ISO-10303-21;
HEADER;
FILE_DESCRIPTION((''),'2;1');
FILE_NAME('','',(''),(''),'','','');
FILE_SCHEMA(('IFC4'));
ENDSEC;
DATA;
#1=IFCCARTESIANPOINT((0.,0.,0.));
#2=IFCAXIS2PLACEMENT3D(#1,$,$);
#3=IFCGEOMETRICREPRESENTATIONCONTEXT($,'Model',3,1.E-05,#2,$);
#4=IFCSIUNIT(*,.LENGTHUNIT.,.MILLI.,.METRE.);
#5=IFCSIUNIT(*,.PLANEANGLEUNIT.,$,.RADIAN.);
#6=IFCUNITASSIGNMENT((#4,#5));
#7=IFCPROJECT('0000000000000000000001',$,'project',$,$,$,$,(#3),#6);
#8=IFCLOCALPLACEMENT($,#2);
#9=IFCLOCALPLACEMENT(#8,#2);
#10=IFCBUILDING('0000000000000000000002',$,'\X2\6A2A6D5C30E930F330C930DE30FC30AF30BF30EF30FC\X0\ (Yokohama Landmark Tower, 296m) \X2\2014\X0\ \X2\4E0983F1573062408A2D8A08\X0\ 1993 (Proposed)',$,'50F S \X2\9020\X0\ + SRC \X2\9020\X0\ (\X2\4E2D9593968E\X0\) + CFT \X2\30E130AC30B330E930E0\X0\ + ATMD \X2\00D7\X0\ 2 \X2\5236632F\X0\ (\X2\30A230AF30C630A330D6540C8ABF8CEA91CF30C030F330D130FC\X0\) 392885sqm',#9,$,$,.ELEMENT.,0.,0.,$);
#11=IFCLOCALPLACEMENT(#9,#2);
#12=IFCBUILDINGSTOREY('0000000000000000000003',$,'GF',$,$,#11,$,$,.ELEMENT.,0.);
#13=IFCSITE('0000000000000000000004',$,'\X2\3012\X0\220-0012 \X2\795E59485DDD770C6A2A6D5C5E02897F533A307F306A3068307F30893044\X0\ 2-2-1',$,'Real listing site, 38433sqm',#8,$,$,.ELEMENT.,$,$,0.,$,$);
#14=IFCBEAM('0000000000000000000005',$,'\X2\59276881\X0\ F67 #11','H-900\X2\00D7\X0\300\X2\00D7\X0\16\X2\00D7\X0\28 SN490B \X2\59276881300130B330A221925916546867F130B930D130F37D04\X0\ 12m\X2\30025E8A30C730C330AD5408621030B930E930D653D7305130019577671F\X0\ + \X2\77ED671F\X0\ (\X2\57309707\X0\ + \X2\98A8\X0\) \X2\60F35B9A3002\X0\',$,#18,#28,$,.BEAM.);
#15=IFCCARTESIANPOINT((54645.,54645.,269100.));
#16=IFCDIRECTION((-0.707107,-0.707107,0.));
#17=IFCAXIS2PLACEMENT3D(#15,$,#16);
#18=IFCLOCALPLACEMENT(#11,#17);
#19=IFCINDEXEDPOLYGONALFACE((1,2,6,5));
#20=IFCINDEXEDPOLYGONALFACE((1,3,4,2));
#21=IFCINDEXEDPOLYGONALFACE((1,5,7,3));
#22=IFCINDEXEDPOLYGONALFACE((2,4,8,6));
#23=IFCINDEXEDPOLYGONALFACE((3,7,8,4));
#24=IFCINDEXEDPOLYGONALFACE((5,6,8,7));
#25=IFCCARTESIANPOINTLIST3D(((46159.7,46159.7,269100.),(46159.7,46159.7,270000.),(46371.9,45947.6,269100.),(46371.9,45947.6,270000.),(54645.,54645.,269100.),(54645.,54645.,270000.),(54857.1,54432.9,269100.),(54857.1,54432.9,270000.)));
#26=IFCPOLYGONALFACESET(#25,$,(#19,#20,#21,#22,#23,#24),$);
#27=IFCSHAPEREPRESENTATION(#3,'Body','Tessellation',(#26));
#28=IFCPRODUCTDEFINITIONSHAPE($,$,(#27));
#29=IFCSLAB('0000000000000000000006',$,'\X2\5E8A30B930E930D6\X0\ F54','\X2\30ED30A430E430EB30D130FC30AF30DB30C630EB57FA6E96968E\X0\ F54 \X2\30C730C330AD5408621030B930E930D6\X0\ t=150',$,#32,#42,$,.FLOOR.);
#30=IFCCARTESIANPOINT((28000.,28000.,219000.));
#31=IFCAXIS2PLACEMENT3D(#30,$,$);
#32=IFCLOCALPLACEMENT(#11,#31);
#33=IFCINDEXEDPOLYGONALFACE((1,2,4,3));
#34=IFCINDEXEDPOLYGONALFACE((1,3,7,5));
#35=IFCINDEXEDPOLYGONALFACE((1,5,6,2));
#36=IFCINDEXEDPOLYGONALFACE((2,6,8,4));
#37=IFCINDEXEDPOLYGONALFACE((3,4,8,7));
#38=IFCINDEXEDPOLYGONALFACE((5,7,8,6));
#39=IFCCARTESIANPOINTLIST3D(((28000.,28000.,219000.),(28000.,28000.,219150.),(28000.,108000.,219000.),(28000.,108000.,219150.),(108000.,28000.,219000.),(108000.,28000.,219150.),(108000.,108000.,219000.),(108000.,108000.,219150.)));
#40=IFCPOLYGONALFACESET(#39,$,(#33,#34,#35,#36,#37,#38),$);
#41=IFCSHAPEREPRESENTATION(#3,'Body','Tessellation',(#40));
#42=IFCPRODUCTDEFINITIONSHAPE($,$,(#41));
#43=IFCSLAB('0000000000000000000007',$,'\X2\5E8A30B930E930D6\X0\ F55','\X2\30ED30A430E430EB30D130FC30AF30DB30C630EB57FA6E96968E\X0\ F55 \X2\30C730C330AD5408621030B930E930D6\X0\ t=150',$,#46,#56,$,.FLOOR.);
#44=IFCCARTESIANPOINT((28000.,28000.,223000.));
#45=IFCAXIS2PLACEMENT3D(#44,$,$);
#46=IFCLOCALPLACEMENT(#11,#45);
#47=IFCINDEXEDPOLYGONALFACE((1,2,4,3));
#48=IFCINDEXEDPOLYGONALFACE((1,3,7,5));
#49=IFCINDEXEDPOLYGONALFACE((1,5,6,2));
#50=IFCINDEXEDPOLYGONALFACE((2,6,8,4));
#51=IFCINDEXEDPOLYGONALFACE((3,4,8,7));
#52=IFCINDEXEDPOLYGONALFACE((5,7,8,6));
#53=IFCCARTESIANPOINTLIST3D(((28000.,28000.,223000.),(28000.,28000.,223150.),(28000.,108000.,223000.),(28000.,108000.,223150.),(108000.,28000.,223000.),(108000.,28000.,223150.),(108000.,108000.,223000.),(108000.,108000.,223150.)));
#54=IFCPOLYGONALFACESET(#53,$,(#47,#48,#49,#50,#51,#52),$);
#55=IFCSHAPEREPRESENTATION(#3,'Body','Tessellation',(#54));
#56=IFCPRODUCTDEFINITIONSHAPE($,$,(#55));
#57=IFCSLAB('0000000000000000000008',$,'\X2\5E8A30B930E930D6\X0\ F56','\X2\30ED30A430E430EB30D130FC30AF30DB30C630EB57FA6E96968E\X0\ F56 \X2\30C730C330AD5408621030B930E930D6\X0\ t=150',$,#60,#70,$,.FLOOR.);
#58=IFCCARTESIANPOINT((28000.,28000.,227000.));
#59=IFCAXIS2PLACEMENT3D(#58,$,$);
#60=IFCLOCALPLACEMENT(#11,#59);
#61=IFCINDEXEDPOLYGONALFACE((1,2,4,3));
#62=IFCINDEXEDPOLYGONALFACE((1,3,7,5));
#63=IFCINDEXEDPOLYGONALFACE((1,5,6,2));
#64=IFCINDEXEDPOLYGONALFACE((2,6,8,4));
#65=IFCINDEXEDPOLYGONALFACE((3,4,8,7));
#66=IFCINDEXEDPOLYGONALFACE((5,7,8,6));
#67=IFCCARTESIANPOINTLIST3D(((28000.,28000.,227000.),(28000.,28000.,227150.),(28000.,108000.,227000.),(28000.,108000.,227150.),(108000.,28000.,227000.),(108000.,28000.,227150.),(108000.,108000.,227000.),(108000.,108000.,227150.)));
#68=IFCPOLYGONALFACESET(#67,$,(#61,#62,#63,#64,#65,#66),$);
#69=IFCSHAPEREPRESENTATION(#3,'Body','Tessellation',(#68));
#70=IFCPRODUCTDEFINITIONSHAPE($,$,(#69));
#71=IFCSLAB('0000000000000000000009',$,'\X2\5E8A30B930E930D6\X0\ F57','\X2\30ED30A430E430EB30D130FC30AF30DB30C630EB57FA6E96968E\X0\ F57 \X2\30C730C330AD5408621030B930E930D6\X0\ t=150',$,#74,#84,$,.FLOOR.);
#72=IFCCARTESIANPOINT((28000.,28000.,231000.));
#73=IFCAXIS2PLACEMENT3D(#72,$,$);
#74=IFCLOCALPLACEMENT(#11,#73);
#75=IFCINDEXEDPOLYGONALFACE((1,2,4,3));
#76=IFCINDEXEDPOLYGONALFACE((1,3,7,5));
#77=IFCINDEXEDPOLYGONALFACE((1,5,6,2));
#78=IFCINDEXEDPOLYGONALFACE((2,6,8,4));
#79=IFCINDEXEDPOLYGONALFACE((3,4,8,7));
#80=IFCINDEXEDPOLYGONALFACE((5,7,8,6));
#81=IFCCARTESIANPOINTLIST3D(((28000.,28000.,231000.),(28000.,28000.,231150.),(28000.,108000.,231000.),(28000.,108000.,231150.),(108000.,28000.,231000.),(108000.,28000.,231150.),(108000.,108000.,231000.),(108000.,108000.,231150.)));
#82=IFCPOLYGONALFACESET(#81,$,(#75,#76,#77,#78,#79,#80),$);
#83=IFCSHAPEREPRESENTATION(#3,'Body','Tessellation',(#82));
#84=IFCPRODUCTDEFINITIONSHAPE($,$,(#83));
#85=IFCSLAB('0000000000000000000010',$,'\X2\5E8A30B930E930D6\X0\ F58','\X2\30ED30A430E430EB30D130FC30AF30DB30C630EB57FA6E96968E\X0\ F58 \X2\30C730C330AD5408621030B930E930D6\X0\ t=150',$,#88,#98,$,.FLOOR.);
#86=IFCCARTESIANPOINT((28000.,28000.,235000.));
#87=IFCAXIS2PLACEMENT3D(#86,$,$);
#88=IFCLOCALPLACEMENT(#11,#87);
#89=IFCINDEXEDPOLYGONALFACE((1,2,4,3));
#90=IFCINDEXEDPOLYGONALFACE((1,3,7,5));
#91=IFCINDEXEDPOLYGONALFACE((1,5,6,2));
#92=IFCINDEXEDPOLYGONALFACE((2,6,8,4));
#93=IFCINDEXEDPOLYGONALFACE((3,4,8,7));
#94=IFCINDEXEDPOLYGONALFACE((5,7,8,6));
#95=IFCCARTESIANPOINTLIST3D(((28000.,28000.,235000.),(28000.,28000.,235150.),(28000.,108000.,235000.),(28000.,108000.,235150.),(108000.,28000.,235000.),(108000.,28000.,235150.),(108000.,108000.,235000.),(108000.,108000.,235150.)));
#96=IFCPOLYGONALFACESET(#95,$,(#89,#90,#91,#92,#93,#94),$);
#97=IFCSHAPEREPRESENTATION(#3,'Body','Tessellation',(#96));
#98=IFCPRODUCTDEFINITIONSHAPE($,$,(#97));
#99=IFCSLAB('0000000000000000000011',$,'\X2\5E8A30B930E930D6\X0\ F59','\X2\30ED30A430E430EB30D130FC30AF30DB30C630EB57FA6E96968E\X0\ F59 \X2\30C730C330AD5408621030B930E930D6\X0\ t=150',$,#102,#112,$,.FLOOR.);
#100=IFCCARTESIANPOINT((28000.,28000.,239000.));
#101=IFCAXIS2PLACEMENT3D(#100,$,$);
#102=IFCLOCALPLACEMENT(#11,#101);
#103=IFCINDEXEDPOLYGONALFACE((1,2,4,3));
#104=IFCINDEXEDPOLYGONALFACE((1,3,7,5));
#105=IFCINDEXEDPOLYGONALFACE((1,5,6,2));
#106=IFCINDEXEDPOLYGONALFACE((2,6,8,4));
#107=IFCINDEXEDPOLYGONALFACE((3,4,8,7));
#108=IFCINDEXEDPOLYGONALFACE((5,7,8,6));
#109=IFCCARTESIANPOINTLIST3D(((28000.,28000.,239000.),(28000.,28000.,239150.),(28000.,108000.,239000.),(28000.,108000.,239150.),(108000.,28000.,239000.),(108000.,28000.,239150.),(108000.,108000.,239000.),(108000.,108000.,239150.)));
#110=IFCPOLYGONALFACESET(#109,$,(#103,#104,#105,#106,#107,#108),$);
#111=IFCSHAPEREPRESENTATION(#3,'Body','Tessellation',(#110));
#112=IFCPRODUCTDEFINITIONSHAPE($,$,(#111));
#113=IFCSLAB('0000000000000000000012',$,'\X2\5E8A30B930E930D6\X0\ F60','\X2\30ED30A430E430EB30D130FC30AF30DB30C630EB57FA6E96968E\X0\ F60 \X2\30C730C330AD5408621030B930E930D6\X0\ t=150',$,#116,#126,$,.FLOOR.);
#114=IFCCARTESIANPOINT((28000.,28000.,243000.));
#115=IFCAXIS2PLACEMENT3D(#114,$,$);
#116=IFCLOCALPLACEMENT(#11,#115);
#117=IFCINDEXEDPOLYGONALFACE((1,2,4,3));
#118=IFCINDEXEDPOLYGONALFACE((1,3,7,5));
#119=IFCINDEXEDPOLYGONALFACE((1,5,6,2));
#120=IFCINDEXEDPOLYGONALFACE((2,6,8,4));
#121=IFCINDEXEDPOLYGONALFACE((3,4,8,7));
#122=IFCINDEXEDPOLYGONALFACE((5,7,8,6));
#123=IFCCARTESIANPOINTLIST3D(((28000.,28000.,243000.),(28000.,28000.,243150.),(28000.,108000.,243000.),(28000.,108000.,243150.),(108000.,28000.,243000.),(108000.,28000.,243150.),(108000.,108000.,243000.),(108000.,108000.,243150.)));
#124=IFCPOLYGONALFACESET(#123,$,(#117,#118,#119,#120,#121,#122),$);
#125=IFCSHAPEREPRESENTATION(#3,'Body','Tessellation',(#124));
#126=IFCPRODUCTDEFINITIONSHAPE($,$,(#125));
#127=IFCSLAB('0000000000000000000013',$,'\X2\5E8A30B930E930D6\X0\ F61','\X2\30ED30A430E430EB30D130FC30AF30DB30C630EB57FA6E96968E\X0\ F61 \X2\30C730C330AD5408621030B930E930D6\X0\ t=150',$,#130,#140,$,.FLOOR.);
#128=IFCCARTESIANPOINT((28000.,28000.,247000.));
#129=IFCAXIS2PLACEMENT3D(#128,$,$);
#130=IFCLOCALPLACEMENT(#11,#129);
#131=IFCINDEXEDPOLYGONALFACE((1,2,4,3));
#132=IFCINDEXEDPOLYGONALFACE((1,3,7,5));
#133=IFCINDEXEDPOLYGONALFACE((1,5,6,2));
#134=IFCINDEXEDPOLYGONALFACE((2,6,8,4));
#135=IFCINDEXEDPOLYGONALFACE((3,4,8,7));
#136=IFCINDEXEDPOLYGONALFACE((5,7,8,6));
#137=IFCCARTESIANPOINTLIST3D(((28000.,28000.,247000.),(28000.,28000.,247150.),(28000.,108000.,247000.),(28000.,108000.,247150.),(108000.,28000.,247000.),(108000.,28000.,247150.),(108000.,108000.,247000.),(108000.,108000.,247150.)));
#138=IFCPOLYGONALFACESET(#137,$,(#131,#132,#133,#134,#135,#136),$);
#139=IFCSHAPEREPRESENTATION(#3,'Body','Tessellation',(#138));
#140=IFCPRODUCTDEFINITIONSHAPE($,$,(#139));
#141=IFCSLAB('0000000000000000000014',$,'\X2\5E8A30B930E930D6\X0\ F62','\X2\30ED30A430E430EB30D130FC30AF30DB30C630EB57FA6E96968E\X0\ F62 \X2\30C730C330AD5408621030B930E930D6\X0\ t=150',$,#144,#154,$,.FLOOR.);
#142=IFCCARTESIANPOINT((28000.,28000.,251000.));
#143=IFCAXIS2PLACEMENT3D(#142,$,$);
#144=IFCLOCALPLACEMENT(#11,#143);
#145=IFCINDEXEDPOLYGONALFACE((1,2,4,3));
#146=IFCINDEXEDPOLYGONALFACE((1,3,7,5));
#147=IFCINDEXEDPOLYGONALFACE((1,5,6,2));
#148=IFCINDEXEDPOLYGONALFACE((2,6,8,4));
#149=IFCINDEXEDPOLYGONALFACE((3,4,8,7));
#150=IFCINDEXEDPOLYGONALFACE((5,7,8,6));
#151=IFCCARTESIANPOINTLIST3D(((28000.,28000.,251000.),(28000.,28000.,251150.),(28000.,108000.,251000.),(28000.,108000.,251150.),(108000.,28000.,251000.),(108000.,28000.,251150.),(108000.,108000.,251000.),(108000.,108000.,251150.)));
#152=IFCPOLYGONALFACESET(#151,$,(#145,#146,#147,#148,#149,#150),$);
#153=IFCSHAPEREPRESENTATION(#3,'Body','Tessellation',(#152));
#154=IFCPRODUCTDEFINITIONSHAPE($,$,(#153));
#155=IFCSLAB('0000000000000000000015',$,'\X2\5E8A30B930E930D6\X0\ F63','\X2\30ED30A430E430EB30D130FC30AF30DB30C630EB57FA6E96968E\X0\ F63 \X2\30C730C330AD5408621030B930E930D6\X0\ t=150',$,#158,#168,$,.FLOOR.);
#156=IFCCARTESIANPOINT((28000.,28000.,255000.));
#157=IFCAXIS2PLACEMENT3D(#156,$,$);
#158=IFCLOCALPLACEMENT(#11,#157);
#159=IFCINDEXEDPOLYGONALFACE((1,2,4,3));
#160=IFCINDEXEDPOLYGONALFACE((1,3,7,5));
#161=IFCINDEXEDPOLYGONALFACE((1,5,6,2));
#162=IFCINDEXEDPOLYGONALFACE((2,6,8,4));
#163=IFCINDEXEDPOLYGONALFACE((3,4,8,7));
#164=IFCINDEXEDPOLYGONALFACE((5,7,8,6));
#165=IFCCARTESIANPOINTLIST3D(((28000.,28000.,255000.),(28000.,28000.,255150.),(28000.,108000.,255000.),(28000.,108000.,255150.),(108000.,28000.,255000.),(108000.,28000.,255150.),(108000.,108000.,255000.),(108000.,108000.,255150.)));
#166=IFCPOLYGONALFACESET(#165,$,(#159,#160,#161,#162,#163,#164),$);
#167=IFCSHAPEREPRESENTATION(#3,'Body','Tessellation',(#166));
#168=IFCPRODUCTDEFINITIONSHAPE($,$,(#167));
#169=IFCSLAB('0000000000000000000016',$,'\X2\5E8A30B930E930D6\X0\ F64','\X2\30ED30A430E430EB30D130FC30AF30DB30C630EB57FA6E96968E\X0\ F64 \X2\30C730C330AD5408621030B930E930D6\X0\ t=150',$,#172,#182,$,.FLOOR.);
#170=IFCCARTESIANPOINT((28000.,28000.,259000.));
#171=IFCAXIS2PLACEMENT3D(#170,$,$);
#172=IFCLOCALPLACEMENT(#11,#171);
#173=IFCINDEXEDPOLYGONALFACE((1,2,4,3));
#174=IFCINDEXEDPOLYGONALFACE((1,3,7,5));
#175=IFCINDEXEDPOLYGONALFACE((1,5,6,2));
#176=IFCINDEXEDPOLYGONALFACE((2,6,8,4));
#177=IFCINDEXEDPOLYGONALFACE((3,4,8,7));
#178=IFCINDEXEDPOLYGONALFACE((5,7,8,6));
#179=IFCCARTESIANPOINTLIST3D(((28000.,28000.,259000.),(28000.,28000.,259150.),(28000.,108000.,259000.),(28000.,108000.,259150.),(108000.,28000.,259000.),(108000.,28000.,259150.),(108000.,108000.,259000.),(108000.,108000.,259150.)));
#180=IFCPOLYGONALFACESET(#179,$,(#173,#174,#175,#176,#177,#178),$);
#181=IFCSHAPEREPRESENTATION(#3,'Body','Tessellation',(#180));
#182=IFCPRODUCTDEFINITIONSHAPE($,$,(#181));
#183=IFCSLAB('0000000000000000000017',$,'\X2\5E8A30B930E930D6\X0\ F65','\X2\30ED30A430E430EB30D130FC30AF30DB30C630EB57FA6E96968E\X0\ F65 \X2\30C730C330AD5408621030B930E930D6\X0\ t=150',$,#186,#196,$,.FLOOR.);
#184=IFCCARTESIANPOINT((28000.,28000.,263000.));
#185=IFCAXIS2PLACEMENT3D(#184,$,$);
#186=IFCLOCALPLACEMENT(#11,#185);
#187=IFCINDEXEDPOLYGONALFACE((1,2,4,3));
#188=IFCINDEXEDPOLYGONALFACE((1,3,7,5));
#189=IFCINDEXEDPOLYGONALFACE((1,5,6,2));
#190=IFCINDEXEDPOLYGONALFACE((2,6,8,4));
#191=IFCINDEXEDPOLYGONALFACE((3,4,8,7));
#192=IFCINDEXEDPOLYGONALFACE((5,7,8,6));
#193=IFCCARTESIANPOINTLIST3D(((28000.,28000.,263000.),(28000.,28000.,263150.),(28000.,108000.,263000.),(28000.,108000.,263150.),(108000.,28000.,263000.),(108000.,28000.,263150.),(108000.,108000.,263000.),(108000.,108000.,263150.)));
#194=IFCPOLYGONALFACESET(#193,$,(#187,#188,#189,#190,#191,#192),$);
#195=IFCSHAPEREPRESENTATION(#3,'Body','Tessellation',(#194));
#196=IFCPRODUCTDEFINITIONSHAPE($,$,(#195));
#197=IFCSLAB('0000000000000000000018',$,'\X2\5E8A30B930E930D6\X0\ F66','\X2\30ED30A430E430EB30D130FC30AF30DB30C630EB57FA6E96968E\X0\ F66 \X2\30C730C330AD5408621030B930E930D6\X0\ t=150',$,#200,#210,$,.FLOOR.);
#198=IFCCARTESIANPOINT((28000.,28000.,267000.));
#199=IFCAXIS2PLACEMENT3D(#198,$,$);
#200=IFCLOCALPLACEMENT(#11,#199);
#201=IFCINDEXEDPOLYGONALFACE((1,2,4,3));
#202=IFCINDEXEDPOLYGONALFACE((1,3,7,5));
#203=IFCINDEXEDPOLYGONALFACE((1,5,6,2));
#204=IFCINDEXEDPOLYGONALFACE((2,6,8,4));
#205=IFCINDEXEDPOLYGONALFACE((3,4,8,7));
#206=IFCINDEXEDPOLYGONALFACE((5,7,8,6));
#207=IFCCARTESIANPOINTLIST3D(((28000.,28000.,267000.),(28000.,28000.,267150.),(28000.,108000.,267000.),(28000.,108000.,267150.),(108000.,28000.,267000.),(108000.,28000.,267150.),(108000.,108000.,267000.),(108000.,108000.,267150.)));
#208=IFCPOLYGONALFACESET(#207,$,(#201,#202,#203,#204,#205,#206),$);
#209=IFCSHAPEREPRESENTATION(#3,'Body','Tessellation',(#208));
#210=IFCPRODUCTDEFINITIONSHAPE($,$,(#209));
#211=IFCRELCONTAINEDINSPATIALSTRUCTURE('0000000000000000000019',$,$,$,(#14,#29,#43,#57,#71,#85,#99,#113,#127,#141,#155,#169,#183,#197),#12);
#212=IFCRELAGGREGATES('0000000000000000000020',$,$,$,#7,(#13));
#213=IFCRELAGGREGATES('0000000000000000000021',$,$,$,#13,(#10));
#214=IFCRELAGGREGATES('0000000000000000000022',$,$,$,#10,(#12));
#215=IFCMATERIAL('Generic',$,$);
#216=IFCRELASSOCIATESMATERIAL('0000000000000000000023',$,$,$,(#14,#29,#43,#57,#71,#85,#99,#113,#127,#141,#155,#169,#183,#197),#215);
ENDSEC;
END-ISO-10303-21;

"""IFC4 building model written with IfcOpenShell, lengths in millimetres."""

from ifc_helpers import new_model, si_unit, frame, frame_2d, origin, place, context, project, spatial, rectangle, extrude, material, element, save


model = new_model("IFC4")

# Units and contexts
model_context = context("Model", 3, precision=1e-05, world=origin())
ifc_project = project(units=[si_unit("LENGTHUNIT", "METRE", prefix="MILLI"), si_unit("PLANEANGLEUNIT", "RADIAN")], contexts=[model_context])

# Site, building, storey
site_placement = place(None, origin())
site = spatial("IfcSite", under=ifc_project, at=site_placement, Name="〒220-0012 神奈川県横浜市西区みなとみらい 2-2-1", ObjectType="Real listing site, 38433sqm", CompositionType="ELEMENT", RefElevation=0.0)
building_placement = place(site_placement, origin())
building = spatial("IfcBuilding", under=site, at=building_placement, Name="横浜ランドマークタワー (Yokohama Landmark Tower, 296m) — 三菱地所設計 1993 (Proposed)", ObjectType="50F S 造 + SRC 造 (中間階) + CFT メガコラム + ATMD × 2 制振 (アクティブ同調質量ダンパー) 392885sqm", CompositionType="ELEMENT", ElevationOfRefHeight=0.0, ElevationOfTerrain=0.0)
storey_placement = place(building_placement, origin())
storey = spatial("IfcBuildingStorey", under=building, at=storey_placement, Name="GF", CompositionType="ELEMENT", Elevation=0.0)

# Beam
ifc_material_1 = material(Name="Generic")
beam_1_placement = place(storey_placement, frame((54645.0, 54645.0, 269100.0), x_axis=(-0.707107, -0.707107, 0.0)))
element("IfcBeam", 1, at=beam_1_placement, inside=storey, material=ifc_material_1, Name="大梁 F67 #11", Description="H-900×300×16×28 SN490B 大梁、コア→外周柱スパン約 12m。床デッキ合成スラブ受け、長期 + 短期 (地震 + 風) 想定。", PredefinedType="BEAM", context=model_context, shape_type="SweptSolid", body=[
    extrude(rectangle(XDim=12000.0, YDim=300.0, at=frame_2d((6000.0, 150.0))), frame((54645.0, 54645.0, 269100.0), x_axis=(-0.707107, -0.707107, 0.0)), (0.0, 0.0, 1.0), 900.0),
])

# Slabs
slab_1_placement = place(storey_placement, frame((28000.0, 28000.0, 219000.0)))
element("IfcSlab", 2, at=slab_1_placement, inside=storey, material=ifc_material_1, Name="床スラブ F54", Description="ロイヤルパークホテル基準階 F54 デッキ合成スラブ t=150", PredefinedType="FLOOR", context=model_context, shape_type="SweptSolid", body=[
    extrude(rectangle(XDim=80000.0, YDim=80000.0, at=frame_2d((40000.0, 40000.0))), frame((28000.0, 28000.0, 219000.0)), (0.0, 0.0, 1.0), 150.0),
])
slab_2_placement = place(storey_placement, frame((28000.0, 28000.0, 223000.0)))
element("IfcSlab", 3, at=slab_2_placement, inside=storey, material=ifc_material_1, Name="床スラブ F55", Description="ロイヤルパークホテル基準階 F55 デッキ合成スラブ t=150", PredefinedType="FLOOR", context=model_context, shape_type="SweptSolid", body=[
    extrude(rectangle(XDim=80000.0, YDim=80000.0, at=frame_2d((40000.0, 40000.0))), frame((28000.0, 28000.0, 223000.0)), (0.0, 0.0, 1.0), 150.0),
])
slab_3_placement = place(storey_placement, frame((28000.0, 28000.0, 227000.0)))
element("IfcSlab", 4, at=slab_3_placement, inside=storey, material=ifc_material_1, Name="床スラブ F56", Description="ロイヤルパークホテル基準階 F56 デッキ合成スラブ t=150", PredefinedType="FLOOR", context=model_context, shape_type="SweptSolid", body=[
    extrude(rectangle(XDim=80000.0, YDim=80000.0, at=frame_2d((40000.0, 40000.0))), frame((28000.0, 28000.0, 227000.0)), (0.0, 0.0, 1.0), 150.0),
])
slab_4_placement = place(storey_placement, frame((28000.0, 28000.0, 231000.0)))
element("IfcSlab", 5, at=slab_4_placement, inside=storey, material=ifc_material_1, Name="床スラブ F57", Description="ロイヤルパークホテル基準階 F57 デッキ合成スラブ t=150", PredefinedType="FLOOR", context=model_context, shape_type="SweptSolid", body=[
    extrude(rectangle(XDim=80000.0, YDim=80000.0, at=frame_2d((40000.0, 40000.0))), frame((28000.0, 28000.0, 231000.0)), (0.0, 0.0, 1.0), 150.0),
])
slab_5_placement = place(storey_placement, frame((28000.0, 28000.0, 235000.0)))
element("IfcSlab", 6, at=slab_5_placement, inside=storey, material=ifc_material_1, Name="床スラブ F58", Description="ロイヤルパークホテル基準階 F58 デッキ合成スラブ t=150", PredefinedType="FLOOR", context=model_context, shape_type="SweptSolid", body=[
    extrude(rectangle(XDim=80000.0, YDim=80000.0, at=frame_2d((40000.0, 40000.0))), frame((28000.0, 28000.0, 235000.0)), (0.0, 0.0, 1.0), 150.0),
])
slab_6_placement = place(storey_placement, frame((28000.0, 28000.0, 239000.0)))
element("IfcSlab", 7, at=slab_6_placement, inside=storey, material=ifc_material_1, Name="床スラブ F59", Description="ロイヤルパークホテル基準階 F59 デッキ合成スラブ t=150", PredefinedType="FLOOR", context=model_context, shape_type="SweptSolid", body=[
    extrude(rectangle(XDim=80000.0, YDim=80000.0, at=frame_2d((40000.0, 40000.0))), frame((28000.0, 28000.0, 239000.0)), (0.0, 0.0, 1.0), 150.0),
])
slab_7_placement = place(storey_placement, frame((28000.0, 28000.0, 243000.0)))
element("IfcSlab", 8, at=slab_7_placement, inside=storey, material=ifc_material_1, Name="床スラブ F60", Description="ロイヤルパークホテル基準階 F60 デッキ合成スラブ t=150", PredefinedType="FLOOR", context=model_context, shape_type="SweptSolid", body=[
    extrude(rectangle(XDim=80000.0, YDim=80000.0, at=frame_2d((40000.0, 40000.0))), frame((28000.0, 28000.0, 243000.0)), (0.0, 0.0, 1.0), 150.0),
])
slab_8_placement = place(storey_placement, frame((28000.0, 28000.0, 247000.0)))
element("IfcSlab", 9, at=slab_8_placement, inside=storey, material=ifc_material_1, Name="床スラブ F61", Description="ロイヤルパークホテル基準階 F61 デッキ合成スラブ t=150", PredefinedType="FLOOR", context=model_context, shape_type="SweptSolid", body=[
    extrude(rectangle(XDim=80000.0, YDim=80000.0, at=frame_2d((40000.0, 40000.0))), frame((28000.0, 28000.0, 247000.0)), (0.0, 0.0, 1.0), 150.0),
])
slab_9_placement = place(storey_placement, frame((28000.0, 28000.0, 251000.0)))
element("IfcSlab", 10, at=slab_9_placement, inside=storey, material=ifc_material_1, Name="床スラブ F62", Description="ロイヤルパークホテル基準階 F62 デッキ合成スラブ t=150", PredefinedType="FLOOR", context=model_context, shape_type="SweptSolid", body=[
    extrude(rectangle(XDim=80000.0, YDim=80000.0, at=frame_2d((40000.0, 40000.0))), frame((28000.0, 28000.0, 251000.0)), (0.0, 0.0, 1.0), 150.0),
])
slab_10_placement = place(storey_placement, frame((28000.0, 28000.0, 255000.0)))
element("IfcSlab", 11, at=slab_10_placement, inside=storey, material=ifc_material_1, Name="床スラブ F63", Description="ロイヤルパークホテル基準階 F63 デッキ合成スラブ t=150", PredefinedType="FLOOR", context=model_context, shape_type="SweptSolid", body=[
    extrude(rectangle(XDim=80000.0, YDim=80000.0, at=frame_2d((40000.0, 40000.0))), frame((28000.0, 28000.0, 255000.0)), (0.0, 0.0, 1.0), 150.0),
])
slab_11_placement = place(storey_placement, frame((28000.0, 28000.0, 259000.0)))
element("IfcSlab", 12, at=slab_11_placement, inside=storey, material=ifc_material_1, Name="床スラブ F64", Description="ロイヤルパークホテル基準階 F64 デッキ合成スラブ t=150", PredefinedType="FLOOR", context=model_context, shape_type="SweptSolid", body=[
    extrude(rectangle(XDim=80000.0, YDim=80000.0, at=frame_2d((40000.0, 40000.0))), frame((28000.0, 28000.0, 259000.0)), (0.0, 0.0, 1.0), 150.0),
])
slab_12_placement = place(storey_placement, frame((28000.0, 28000.0, 263000.0)))
element("IfcSlab", 13, at=slab_12_placement, inside=storey, material=ifc_material_1, Name="床スラブ F65", Description="ロイヤルパークホテル基準階 F65 デッキ合成スラブ t=150", PredefinedType="FLOOR", context=model_context, shape_type="SweptSolid", body=[
    extrude(rectangle(XDim=80000.0, YDim=80000.0, at=frame_2d((40000.0, 40000.0))), frame((28000.0, 28000.0, 263000.0)), (0.0, 0.0, 1.0), 150.0),
])
slab_13_placement = place(storey_placement, frame((28000.0, 28000.0, 267000.0)))
element("IfcSlab", 14, at=slab_13_placement, inside=storey, material=ifc_material_1, Name="床スラブ F66", Description="ロイヤルパークホテル基準階 F66 デッキ合成スラブ t=150", PredefinedType="FLOOR", context=model_context, shape_type="SweptSolid", body=[
    extrude(rectangle(XDim=80000.0, YDim=80000.0, at=frame_2d((40000.0, 40000.0))), frame((28000.0, 28000.0, 267000.0)), (0.0, 0.0, 1.0), 150.0),
])

save(model, "model.ifc")
